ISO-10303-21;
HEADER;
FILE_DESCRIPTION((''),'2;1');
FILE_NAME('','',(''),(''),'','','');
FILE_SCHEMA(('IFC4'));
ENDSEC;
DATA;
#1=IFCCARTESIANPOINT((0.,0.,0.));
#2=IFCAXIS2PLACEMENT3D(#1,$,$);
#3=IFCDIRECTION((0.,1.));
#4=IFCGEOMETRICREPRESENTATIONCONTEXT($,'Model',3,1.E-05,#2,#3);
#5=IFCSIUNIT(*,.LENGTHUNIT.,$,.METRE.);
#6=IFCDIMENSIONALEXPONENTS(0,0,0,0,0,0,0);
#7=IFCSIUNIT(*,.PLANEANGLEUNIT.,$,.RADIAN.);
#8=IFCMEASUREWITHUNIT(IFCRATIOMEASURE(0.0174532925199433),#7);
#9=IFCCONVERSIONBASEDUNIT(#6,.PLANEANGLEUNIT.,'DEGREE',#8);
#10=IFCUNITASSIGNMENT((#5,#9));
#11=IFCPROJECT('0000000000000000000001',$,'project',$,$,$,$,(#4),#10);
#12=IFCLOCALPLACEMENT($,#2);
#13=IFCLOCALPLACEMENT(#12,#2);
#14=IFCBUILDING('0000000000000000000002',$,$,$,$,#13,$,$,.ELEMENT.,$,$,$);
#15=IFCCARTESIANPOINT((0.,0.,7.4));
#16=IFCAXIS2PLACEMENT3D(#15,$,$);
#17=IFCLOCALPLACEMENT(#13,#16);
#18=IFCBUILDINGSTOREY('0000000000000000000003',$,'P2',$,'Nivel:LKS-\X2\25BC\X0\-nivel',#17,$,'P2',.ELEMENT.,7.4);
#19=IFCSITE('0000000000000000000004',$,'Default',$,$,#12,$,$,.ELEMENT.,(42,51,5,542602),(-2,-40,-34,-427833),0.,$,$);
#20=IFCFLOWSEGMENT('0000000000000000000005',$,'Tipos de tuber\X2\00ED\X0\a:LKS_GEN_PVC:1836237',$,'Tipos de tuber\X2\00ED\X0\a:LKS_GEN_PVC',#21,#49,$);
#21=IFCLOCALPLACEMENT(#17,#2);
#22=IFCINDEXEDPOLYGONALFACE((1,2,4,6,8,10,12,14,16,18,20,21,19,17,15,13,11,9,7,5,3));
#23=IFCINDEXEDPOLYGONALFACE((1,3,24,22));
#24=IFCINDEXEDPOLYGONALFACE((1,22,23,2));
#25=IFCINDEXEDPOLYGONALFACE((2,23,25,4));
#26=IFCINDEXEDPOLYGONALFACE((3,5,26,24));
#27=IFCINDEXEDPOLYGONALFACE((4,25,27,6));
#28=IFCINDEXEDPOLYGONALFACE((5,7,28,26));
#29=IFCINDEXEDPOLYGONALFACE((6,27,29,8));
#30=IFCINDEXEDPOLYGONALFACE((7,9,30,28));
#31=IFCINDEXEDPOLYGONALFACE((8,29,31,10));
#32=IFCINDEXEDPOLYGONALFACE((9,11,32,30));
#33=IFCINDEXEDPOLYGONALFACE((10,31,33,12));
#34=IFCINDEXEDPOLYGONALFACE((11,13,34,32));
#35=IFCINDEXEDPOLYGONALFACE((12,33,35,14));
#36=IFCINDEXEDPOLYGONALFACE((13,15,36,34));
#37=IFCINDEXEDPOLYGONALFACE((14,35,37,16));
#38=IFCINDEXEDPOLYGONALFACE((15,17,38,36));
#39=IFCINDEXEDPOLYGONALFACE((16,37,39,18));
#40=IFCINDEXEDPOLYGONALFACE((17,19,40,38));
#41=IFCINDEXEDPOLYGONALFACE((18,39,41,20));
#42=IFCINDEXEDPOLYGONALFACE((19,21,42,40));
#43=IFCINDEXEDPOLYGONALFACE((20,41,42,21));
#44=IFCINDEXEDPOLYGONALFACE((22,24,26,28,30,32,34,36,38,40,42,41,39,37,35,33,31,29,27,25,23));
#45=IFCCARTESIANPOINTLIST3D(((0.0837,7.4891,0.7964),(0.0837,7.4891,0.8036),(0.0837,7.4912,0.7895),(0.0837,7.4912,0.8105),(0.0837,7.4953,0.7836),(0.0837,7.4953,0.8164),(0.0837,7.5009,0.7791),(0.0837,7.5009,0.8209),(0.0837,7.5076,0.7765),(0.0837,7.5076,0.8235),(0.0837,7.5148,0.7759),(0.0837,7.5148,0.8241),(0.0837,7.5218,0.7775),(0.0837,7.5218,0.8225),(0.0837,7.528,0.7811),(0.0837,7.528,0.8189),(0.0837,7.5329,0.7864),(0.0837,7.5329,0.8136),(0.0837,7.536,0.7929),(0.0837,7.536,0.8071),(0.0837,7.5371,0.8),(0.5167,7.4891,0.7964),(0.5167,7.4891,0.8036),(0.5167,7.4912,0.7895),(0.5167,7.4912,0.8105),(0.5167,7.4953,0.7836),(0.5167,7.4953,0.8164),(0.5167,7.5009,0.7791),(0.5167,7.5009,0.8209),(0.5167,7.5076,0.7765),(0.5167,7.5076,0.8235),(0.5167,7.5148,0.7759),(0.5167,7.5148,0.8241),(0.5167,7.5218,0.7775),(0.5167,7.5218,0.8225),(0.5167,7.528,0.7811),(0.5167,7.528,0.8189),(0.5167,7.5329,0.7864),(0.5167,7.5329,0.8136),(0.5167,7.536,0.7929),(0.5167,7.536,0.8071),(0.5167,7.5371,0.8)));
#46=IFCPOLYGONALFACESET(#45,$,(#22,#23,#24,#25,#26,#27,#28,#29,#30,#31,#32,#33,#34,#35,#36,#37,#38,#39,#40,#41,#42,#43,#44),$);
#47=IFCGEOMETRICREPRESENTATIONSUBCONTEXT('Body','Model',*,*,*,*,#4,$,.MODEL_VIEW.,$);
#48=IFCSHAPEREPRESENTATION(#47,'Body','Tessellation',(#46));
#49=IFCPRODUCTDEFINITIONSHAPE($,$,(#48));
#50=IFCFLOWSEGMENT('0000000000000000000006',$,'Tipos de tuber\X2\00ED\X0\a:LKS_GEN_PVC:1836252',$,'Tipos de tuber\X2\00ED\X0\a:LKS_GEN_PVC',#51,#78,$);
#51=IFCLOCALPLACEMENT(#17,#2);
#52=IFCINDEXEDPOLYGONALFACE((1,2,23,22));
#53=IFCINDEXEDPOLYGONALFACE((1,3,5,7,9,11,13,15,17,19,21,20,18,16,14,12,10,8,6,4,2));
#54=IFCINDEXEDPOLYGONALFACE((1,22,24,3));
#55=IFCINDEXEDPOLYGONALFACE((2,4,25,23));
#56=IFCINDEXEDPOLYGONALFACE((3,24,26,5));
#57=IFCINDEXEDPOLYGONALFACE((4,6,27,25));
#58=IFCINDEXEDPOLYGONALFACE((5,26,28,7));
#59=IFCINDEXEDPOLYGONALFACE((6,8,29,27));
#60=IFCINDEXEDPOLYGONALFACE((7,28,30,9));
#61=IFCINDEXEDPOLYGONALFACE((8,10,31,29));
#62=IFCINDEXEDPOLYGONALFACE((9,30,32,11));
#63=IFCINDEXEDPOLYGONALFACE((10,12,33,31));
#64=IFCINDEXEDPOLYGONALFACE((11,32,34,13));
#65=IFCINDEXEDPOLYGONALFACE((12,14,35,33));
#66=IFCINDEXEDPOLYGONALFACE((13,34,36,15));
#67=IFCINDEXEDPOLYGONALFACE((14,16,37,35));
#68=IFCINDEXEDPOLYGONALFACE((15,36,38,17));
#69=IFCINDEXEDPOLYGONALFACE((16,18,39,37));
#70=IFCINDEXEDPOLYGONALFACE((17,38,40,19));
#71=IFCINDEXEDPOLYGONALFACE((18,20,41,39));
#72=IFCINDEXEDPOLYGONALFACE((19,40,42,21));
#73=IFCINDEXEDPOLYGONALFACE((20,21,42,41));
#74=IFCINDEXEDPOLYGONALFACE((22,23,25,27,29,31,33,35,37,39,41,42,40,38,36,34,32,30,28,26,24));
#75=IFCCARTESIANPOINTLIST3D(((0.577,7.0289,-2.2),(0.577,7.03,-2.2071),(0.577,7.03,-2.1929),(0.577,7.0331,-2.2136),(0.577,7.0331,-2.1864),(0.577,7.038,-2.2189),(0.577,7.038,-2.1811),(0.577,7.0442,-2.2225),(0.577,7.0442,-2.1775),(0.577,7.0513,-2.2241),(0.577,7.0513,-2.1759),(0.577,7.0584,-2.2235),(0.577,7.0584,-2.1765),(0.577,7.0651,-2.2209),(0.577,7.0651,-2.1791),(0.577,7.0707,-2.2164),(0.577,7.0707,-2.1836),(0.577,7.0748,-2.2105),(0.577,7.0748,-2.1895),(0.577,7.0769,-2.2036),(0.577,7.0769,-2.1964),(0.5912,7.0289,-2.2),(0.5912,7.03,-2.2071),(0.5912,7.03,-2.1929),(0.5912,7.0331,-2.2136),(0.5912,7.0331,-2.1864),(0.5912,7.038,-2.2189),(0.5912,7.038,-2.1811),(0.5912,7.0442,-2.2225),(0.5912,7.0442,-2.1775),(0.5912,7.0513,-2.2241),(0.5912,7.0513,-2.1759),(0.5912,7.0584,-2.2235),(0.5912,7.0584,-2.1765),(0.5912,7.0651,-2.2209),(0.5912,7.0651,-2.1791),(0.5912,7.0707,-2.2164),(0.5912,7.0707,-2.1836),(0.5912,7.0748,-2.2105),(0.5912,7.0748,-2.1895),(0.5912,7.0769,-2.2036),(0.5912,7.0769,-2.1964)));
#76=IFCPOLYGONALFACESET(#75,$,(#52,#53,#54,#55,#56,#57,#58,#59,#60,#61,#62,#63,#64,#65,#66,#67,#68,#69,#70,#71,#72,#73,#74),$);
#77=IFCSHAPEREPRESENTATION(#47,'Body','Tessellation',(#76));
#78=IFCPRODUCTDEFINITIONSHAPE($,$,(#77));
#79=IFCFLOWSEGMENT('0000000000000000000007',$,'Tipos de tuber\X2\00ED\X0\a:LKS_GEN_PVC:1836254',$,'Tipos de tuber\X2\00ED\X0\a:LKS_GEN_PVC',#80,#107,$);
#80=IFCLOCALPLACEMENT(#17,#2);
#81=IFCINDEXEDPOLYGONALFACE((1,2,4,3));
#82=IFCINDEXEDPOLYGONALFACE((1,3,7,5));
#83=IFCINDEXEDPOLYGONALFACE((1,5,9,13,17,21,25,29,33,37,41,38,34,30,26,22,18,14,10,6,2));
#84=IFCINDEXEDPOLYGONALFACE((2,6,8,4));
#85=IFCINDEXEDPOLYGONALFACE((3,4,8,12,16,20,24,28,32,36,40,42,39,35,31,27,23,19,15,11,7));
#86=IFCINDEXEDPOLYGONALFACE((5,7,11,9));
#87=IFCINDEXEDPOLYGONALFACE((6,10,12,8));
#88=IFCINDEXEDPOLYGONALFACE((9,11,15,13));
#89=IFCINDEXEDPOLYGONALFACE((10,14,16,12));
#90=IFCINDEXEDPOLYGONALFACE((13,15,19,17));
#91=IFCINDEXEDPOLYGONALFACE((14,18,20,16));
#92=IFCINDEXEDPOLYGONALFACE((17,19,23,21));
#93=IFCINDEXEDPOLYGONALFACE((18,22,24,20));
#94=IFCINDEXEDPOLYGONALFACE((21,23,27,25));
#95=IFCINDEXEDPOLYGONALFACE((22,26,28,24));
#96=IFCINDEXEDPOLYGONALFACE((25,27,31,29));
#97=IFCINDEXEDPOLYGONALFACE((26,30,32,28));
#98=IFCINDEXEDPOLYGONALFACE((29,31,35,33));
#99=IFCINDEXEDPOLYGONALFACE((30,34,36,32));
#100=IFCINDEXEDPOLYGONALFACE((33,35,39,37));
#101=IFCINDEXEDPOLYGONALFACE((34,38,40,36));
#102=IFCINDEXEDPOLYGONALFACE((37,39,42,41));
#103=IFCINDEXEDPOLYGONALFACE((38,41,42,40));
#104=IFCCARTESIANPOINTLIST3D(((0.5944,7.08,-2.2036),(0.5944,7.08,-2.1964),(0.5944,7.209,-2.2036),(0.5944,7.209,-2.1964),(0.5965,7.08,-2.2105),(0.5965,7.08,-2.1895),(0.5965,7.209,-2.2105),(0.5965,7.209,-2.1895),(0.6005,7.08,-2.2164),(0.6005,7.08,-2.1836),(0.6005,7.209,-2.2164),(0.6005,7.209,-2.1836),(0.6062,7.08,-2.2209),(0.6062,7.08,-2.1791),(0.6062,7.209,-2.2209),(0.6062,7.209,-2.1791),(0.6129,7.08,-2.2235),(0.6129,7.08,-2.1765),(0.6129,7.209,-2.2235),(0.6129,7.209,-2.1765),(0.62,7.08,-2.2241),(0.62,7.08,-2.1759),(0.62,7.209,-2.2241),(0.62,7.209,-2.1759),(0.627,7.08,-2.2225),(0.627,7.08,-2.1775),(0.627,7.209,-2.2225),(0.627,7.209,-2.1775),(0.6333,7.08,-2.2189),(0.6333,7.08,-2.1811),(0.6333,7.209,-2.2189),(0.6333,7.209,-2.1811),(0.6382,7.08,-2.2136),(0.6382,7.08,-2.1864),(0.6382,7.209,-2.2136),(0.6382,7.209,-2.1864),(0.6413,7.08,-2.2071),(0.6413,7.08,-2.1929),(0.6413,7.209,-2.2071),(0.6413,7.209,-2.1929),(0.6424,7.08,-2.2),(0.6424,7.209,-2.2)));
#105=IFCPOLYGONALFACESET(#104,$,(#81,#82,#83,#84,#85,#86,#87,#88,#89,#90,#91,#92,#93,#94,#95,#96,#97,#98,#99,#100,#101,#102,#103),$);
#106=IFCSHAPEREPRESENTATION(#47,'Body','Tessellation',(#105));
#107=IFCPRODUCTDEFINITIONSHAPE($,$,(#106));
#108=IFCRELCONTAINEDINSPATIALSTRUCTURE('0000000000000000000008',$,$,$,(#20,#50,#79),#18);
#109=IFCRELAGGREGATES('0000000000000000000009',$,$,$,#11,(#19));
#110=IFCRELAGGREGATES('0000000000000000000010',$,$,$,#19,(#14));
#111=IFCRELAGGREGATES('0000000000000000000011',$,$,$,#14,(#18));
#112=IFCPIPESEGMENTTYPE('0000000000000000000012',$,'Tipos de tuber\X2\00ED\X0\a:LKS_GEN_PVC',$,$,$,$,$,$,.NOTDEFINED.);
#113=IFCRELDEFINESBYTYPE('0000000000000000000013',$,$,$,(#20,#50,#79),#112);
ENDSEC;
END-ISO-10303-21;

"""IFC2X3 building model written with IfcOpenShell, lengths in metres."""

from ifc_helpers import new_model, entity, si_unit, converted_unit, direction, frame, frame_2d, origin, origin_2d_with_axis, place, context, subcontext, project, spatial, circle, extrude, type_object, element, save


model = new_model("IFC2X3")

# Units and contexts
model_context = context("Model", 3, precision=1e-05, world=origin(), true_north=direction((0.0, 1.0)))
body_context = subcontext(model_context, "Body", "Model", "MODEL_VIEW")
ifc_project = project(units=[si_unit("LENGTHUNIT", "METRE"), converted_unit("PLANEANGLEUNIT", "DEGREE", entity("IfcRatioMeasure", 0.0174532925199433), si_unit("PLANEANGLEUNIT", "RADIAN"), dimensions=[0, 0, 0, 0, 0, 0, 0])], contexts=[model_context])

# Site, building, storey
site_placement = place(None, origin())
site = spatial("IfcSite", under=ifc_project, at=site_placement, Name="Default", CompositionType="ELEMENT", RefLatitude=(42, 51, 5, 542602), RefLongitude=(-2, -40, -34, -427833), RefElevation=0.0)
building_placement = place(site_placement, origin())
building = spatial("IfcBuilding", under=site, at=building_placement, CompositionType="ELEMENT")
storey_placement = place(building_placement, frame((0.0, 0.0, 7.4)))
storey = spatial("IfcBuildingStorey", under=building, at=storey_placement, Name="P2", ObjectType="Nivel:LKS-▼-nivel", LongName="P2", CompositionType="ELEMENT", Elevation=7.4)

# Flow segments
pipe_segment_type_1 = type_object("IfcPipeSegmentType", Name="Tipos de tubería:LKS_GEN_PVC", PredefinedType="NOTDEFINED")
flow_segment_1_placement = place(storey_placement, origin())
element("IfcFlowSegment", 1, at=flow_segment_1_placement, inside=storey, type_object=pipe_segment_type_1, Name="Tipos de tubería:LKS_GEN_PVC:1836237", ObjectType="Tipos de tubería:LKS_GEN_PVC", context=body_context, shape_type="SweptSolid", body=[
    extrude(circle(Radius=0.0241, at=frame_2d((0.0, 0.0), x_axis=(1.0, 0.0))), frame((0.0837, 7.513, 0.8), z_axis=(1.0, 0.0, 0.0), x_axis=(0.0, 1.0, 0.0)), (0.0, 0.0, 1.0), 0.433),
])
flow_segment_2_placement = place(storey_placement, origin())
element("IfcFlowSegment", 2, at=flow_segment_2_placement, inside=storey, type_object=pipe_segment_type_1, Name="Tipos de tubería:LKS_GEN_PVC:1836252", ObjectType="Tipos de tubería:LKS_GEN_PVC", context=body_context, shape_type="SweptSolid", body=[
    extrude(circle(Radius=0.0241, at=origin_2d_with_axis()), frame((0.577, 7.0531, -2.2), z_axis=(1.0, 0.0, 0.0), x_axis=(0.0, -1.0, 0.0)), (0.0, 0.0, 1.0), 0.0142),
])
flow_segment_3_placement = place(storey_placement, origin())
element("IfcFlowSegment", 3, at=flow_segment_3_placement, inside=storey, type_object=pipe_segment_type_1, Name="Tipos de tubería:LKS_GEN_PVC:1836254", ObjectType="Tipos de tubería:LKS_GEN_PVC", context=body_context, shape_type="SweptSolid", body=[
    extrude(circle(Radius=0.0241, at=frame_2d((0.0, 0.0), x_axis=(1.0, 0.0))), frame((0.6182, 7.08, -2.2), z_axis=(0.0, 1.0, 0.0), x_axis=(1.0, 0.0, 0.0)), (0.0, 0.0, 1.0), 0.129),
])

save(model, "model.ifc")
